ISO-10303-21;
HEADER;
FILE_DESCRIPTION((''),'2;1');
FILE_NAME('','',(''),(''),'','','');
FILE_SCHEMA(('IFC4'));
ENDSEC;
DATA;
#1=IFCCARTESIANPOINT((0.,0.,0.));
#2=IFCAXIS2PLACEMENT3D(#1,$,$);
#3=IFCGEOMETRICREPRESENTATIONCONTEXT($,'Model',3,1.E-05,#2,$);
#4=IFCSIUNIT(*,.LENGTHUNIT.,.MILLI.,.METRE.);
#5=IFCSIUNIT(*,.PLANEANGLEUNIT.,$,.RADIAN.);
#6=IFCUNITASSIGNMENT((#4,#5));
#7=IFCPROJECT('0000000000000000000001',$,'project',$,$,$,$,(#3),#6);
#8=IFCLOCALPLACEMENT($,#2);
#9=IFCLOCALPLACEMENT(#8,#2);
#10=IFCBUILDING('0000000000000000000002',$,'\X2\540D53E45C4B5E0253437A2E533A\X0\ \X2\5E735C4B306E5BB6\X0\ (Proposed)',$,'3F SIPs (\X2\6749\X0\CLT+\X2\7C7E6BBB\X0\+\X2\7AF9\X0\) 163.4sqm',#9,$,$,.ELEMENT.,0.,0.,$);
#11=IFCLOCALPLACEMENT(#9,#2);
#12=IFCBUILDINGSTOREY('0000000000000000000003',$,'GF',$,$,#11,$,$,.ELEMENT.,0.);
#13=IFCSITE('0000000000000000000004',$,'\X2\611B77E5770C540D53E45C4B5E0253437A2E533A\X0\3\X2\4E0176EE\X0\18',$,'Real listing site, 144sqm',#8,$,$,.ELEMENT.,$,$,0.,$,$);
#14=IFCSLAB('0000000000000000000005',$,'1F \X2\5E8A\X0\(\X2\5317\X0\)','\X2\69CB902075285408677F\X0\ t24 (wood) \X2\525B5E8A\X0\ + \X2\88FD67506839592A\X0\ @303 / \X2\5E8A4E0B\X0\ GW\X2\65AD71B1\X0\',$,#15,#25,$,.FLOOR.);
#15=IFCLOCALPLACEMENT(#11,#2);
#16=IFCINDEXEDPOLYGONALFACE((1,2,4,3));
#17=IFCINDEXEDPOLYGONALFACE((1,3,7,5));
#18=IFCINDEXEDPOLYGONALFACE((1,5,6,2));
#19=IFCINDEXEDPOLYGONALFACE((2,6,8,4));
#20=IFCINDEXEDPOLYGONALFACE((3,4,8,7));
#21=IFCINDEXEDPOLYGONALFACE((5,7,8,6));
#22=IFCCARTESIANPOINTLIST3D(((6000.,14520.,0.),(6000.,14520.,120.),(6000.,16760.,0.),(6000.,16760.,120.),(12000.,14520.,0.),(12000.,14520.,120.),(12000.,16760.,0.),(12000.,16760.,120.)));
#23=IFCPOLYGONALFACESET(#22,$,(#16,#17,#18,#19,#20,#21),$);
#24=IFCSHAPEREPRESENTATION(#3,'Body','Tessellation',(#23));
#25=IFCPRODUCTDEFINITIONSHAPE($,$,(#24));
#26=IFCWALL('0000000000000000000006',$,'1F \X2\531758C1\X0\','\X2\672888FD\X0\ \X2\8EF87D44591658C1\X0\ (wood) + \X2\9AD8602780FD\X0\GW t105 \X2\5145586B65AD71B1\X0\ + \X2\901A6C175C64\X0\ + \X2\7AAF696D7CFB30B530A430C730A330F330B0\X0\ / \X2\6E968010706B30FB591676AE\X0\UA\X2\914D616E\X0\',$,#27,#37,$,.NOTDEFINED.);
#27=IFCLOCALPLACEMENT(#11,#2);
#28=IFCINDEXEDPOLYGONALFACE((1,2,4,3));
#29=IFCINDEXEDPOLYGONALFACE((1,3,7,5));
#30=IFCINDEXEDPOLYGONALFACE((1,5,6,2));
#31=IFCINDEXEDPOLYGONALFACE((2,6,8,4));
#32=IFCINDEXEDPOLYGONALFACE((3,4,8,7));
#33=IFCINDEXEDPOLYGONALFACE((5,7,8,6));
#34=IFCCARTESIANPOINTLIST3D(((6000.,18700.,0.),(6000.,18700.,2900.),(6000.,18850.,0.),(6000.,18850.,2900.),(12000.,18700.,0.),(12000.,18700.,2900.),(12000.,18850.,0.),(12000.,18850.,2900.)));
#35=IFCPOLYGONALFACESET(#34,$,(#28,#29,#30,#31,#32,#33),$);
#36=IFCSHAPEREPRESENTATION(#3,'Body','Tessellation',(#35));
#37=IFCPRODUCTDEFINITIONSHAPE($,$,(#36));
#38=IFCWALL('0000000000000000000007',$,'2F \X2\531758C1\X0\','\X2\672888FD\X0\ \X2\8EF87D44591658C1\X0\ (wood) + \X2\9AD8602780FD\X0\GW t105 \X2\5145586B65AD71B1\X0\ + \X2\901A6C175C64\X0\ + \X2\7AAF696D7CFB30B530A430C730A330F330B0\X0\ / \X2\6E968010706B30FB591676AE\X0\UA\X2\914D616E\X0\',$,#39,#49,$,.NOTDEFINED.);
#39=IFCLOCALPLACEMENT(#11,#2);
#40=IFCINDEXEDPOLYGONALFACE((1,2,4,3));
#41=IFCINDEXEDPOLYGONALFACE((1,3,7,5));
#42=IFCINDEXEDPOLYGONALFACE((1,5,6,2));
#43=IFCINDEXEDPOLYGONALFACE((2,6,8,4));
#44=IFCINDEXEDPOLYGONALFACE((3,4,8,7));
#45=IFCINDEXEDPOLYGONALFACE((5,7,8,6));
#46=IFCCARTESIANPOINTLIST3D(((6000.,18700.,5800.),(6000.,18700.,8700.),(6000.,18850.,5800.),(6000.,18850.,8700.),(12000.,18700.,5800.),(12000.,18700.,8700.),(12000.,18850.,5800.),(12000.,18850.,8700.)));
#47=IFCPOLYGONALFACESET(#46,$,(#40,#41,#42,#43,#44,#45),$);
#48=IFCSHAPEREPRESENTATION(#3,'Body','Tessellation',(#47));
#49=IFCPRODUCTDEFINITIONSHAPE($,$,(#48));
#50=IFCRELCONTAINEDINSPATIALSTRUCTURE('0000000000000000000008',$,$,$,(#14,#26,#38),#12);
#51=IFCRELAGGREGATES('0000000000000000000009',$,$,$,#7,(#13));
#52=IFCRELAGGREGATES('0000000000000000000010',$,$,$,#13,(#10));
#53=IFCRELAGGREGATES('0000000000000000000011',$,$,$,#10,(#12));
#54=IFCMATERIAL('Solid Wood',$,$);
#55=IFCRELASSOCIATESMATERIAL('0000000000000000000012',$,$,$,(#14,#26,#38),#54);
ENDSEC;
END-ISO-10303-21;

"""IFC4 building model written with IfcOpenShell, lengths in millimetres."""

from ifc_helpers import new_model, si_unit, frame, frame_2d, origin, place, context, project, spatial, rectangle, extrude, material, element, save


model = new_model("IFC4")

# Units and contexts
model_context = context("Model", 3, precision=1e-05, world=origin())
ifc_project = project(units=[si_unit("LENGTHUNIT", "METRE", prefix="MILLI"), si_unit("PLANEANGLEUNIT", "RADIAN")], contexts=[model_context])

# Site, building, storey
site_placement = place(None, origin())
site = spatial("IfcSite", under=ifc_project, at=site_placement, Name="愛知県名古屋市千種区3丁目18", ObjectType="Real listing site, 144sqm", CompositionType="ELEMENT", RefElevation=0.0)
building_placement = place(site_placement, origin())
building = spatial("IfcBuilding", under=site, at=building_placement, Name="名古屋市千種区 平屋の家 (Proposed)", ObjectType="3F SIPs (杉CLT+籾殻+竹) 163.4sqm", CompositionType="ELEMENT", ElevationOfRefHeight=0.0, ElevationOfTerrain=0.0)
storey_placement = place(building_placement, origin())
storey = spatial("IfcBuildingStorey", under=building, at=storey_placement, Name="GF", CompositionType="ELEMENT", Elevation=0.0)

# Slab
ifc_material_1 = material(Name="Solid Wood")
slab_1_placement = place(storey_placement, frame((3000.0, 7260.0, 0.0)))
element("IfcSlab", 1, at=slab_1_placement, inside=storey, material=ifc_material_1, Name="1F 床(北)", Description="構造用合板 t24 (wood) 剛床 + 製材根太 @303 / 床下 GW断熱", PredefinedType="FLOOR", context=model_context, shape_type="SweptSolid", body=[
    extrude(rectangle(XDim=6000.0, YDim=2240.0, at=frame_2d((3000.0, 1120.0))), frame((3000.0, 7260.0, 0.0)), (0.0, 0.0, 1.0), 120.0),
])

# Wall
wall_1_placement = place(storey_placement, frame((3000.0, 9350.0, 0.0)))
element("IfcWall", 2, at=wall_1_placement, inside=storey, material=ifc_material_1, Name="1F 北壁", Description="木製 軸組外壁 (wood) + 高性能GW t105 充填断熱 + 通気層 + 窯業系サイディング / 準耐火・外皮UA配慮", PredefinedType="NOTDEFINED", context=model_context, shape_type="SweptSolid", body=[
    extrude(rectangle(XDim=6000.0, YDim=150.0, at=frame_2d((3000.0, 75.0))), frame((3000.0, 9350.0, 0.0)), (0.0, 0.0, 1.0), 2900.0),
])

# Wall
wall_2_placement = place(storey_placement, frame((3000.0, 9350.0, 2900.0)))
element("IfcWall", 3, at=wall_2_placement, inside=storey, material=ifc_material_1, Name="2F 北壁", Description="木製 軸組外壁 (wood) + 高性能GW t105 充填断熱 + 通気層 + 窯業系サイディング / 準耐火・外皮UA配慮", PredefinedType="NOTDEFINED", context=model_context, shape_type="SweptSolid", body=[
    extrude(rectangle(XDim=6000.0, YDim=150.0, at=frame_2d((3000.0, 75.0))), frame((3000.0, 9350.0, 2900.0)), (0.0, 0.0, 1.0), 2900.0),
])

save(model, "model.ifc")
